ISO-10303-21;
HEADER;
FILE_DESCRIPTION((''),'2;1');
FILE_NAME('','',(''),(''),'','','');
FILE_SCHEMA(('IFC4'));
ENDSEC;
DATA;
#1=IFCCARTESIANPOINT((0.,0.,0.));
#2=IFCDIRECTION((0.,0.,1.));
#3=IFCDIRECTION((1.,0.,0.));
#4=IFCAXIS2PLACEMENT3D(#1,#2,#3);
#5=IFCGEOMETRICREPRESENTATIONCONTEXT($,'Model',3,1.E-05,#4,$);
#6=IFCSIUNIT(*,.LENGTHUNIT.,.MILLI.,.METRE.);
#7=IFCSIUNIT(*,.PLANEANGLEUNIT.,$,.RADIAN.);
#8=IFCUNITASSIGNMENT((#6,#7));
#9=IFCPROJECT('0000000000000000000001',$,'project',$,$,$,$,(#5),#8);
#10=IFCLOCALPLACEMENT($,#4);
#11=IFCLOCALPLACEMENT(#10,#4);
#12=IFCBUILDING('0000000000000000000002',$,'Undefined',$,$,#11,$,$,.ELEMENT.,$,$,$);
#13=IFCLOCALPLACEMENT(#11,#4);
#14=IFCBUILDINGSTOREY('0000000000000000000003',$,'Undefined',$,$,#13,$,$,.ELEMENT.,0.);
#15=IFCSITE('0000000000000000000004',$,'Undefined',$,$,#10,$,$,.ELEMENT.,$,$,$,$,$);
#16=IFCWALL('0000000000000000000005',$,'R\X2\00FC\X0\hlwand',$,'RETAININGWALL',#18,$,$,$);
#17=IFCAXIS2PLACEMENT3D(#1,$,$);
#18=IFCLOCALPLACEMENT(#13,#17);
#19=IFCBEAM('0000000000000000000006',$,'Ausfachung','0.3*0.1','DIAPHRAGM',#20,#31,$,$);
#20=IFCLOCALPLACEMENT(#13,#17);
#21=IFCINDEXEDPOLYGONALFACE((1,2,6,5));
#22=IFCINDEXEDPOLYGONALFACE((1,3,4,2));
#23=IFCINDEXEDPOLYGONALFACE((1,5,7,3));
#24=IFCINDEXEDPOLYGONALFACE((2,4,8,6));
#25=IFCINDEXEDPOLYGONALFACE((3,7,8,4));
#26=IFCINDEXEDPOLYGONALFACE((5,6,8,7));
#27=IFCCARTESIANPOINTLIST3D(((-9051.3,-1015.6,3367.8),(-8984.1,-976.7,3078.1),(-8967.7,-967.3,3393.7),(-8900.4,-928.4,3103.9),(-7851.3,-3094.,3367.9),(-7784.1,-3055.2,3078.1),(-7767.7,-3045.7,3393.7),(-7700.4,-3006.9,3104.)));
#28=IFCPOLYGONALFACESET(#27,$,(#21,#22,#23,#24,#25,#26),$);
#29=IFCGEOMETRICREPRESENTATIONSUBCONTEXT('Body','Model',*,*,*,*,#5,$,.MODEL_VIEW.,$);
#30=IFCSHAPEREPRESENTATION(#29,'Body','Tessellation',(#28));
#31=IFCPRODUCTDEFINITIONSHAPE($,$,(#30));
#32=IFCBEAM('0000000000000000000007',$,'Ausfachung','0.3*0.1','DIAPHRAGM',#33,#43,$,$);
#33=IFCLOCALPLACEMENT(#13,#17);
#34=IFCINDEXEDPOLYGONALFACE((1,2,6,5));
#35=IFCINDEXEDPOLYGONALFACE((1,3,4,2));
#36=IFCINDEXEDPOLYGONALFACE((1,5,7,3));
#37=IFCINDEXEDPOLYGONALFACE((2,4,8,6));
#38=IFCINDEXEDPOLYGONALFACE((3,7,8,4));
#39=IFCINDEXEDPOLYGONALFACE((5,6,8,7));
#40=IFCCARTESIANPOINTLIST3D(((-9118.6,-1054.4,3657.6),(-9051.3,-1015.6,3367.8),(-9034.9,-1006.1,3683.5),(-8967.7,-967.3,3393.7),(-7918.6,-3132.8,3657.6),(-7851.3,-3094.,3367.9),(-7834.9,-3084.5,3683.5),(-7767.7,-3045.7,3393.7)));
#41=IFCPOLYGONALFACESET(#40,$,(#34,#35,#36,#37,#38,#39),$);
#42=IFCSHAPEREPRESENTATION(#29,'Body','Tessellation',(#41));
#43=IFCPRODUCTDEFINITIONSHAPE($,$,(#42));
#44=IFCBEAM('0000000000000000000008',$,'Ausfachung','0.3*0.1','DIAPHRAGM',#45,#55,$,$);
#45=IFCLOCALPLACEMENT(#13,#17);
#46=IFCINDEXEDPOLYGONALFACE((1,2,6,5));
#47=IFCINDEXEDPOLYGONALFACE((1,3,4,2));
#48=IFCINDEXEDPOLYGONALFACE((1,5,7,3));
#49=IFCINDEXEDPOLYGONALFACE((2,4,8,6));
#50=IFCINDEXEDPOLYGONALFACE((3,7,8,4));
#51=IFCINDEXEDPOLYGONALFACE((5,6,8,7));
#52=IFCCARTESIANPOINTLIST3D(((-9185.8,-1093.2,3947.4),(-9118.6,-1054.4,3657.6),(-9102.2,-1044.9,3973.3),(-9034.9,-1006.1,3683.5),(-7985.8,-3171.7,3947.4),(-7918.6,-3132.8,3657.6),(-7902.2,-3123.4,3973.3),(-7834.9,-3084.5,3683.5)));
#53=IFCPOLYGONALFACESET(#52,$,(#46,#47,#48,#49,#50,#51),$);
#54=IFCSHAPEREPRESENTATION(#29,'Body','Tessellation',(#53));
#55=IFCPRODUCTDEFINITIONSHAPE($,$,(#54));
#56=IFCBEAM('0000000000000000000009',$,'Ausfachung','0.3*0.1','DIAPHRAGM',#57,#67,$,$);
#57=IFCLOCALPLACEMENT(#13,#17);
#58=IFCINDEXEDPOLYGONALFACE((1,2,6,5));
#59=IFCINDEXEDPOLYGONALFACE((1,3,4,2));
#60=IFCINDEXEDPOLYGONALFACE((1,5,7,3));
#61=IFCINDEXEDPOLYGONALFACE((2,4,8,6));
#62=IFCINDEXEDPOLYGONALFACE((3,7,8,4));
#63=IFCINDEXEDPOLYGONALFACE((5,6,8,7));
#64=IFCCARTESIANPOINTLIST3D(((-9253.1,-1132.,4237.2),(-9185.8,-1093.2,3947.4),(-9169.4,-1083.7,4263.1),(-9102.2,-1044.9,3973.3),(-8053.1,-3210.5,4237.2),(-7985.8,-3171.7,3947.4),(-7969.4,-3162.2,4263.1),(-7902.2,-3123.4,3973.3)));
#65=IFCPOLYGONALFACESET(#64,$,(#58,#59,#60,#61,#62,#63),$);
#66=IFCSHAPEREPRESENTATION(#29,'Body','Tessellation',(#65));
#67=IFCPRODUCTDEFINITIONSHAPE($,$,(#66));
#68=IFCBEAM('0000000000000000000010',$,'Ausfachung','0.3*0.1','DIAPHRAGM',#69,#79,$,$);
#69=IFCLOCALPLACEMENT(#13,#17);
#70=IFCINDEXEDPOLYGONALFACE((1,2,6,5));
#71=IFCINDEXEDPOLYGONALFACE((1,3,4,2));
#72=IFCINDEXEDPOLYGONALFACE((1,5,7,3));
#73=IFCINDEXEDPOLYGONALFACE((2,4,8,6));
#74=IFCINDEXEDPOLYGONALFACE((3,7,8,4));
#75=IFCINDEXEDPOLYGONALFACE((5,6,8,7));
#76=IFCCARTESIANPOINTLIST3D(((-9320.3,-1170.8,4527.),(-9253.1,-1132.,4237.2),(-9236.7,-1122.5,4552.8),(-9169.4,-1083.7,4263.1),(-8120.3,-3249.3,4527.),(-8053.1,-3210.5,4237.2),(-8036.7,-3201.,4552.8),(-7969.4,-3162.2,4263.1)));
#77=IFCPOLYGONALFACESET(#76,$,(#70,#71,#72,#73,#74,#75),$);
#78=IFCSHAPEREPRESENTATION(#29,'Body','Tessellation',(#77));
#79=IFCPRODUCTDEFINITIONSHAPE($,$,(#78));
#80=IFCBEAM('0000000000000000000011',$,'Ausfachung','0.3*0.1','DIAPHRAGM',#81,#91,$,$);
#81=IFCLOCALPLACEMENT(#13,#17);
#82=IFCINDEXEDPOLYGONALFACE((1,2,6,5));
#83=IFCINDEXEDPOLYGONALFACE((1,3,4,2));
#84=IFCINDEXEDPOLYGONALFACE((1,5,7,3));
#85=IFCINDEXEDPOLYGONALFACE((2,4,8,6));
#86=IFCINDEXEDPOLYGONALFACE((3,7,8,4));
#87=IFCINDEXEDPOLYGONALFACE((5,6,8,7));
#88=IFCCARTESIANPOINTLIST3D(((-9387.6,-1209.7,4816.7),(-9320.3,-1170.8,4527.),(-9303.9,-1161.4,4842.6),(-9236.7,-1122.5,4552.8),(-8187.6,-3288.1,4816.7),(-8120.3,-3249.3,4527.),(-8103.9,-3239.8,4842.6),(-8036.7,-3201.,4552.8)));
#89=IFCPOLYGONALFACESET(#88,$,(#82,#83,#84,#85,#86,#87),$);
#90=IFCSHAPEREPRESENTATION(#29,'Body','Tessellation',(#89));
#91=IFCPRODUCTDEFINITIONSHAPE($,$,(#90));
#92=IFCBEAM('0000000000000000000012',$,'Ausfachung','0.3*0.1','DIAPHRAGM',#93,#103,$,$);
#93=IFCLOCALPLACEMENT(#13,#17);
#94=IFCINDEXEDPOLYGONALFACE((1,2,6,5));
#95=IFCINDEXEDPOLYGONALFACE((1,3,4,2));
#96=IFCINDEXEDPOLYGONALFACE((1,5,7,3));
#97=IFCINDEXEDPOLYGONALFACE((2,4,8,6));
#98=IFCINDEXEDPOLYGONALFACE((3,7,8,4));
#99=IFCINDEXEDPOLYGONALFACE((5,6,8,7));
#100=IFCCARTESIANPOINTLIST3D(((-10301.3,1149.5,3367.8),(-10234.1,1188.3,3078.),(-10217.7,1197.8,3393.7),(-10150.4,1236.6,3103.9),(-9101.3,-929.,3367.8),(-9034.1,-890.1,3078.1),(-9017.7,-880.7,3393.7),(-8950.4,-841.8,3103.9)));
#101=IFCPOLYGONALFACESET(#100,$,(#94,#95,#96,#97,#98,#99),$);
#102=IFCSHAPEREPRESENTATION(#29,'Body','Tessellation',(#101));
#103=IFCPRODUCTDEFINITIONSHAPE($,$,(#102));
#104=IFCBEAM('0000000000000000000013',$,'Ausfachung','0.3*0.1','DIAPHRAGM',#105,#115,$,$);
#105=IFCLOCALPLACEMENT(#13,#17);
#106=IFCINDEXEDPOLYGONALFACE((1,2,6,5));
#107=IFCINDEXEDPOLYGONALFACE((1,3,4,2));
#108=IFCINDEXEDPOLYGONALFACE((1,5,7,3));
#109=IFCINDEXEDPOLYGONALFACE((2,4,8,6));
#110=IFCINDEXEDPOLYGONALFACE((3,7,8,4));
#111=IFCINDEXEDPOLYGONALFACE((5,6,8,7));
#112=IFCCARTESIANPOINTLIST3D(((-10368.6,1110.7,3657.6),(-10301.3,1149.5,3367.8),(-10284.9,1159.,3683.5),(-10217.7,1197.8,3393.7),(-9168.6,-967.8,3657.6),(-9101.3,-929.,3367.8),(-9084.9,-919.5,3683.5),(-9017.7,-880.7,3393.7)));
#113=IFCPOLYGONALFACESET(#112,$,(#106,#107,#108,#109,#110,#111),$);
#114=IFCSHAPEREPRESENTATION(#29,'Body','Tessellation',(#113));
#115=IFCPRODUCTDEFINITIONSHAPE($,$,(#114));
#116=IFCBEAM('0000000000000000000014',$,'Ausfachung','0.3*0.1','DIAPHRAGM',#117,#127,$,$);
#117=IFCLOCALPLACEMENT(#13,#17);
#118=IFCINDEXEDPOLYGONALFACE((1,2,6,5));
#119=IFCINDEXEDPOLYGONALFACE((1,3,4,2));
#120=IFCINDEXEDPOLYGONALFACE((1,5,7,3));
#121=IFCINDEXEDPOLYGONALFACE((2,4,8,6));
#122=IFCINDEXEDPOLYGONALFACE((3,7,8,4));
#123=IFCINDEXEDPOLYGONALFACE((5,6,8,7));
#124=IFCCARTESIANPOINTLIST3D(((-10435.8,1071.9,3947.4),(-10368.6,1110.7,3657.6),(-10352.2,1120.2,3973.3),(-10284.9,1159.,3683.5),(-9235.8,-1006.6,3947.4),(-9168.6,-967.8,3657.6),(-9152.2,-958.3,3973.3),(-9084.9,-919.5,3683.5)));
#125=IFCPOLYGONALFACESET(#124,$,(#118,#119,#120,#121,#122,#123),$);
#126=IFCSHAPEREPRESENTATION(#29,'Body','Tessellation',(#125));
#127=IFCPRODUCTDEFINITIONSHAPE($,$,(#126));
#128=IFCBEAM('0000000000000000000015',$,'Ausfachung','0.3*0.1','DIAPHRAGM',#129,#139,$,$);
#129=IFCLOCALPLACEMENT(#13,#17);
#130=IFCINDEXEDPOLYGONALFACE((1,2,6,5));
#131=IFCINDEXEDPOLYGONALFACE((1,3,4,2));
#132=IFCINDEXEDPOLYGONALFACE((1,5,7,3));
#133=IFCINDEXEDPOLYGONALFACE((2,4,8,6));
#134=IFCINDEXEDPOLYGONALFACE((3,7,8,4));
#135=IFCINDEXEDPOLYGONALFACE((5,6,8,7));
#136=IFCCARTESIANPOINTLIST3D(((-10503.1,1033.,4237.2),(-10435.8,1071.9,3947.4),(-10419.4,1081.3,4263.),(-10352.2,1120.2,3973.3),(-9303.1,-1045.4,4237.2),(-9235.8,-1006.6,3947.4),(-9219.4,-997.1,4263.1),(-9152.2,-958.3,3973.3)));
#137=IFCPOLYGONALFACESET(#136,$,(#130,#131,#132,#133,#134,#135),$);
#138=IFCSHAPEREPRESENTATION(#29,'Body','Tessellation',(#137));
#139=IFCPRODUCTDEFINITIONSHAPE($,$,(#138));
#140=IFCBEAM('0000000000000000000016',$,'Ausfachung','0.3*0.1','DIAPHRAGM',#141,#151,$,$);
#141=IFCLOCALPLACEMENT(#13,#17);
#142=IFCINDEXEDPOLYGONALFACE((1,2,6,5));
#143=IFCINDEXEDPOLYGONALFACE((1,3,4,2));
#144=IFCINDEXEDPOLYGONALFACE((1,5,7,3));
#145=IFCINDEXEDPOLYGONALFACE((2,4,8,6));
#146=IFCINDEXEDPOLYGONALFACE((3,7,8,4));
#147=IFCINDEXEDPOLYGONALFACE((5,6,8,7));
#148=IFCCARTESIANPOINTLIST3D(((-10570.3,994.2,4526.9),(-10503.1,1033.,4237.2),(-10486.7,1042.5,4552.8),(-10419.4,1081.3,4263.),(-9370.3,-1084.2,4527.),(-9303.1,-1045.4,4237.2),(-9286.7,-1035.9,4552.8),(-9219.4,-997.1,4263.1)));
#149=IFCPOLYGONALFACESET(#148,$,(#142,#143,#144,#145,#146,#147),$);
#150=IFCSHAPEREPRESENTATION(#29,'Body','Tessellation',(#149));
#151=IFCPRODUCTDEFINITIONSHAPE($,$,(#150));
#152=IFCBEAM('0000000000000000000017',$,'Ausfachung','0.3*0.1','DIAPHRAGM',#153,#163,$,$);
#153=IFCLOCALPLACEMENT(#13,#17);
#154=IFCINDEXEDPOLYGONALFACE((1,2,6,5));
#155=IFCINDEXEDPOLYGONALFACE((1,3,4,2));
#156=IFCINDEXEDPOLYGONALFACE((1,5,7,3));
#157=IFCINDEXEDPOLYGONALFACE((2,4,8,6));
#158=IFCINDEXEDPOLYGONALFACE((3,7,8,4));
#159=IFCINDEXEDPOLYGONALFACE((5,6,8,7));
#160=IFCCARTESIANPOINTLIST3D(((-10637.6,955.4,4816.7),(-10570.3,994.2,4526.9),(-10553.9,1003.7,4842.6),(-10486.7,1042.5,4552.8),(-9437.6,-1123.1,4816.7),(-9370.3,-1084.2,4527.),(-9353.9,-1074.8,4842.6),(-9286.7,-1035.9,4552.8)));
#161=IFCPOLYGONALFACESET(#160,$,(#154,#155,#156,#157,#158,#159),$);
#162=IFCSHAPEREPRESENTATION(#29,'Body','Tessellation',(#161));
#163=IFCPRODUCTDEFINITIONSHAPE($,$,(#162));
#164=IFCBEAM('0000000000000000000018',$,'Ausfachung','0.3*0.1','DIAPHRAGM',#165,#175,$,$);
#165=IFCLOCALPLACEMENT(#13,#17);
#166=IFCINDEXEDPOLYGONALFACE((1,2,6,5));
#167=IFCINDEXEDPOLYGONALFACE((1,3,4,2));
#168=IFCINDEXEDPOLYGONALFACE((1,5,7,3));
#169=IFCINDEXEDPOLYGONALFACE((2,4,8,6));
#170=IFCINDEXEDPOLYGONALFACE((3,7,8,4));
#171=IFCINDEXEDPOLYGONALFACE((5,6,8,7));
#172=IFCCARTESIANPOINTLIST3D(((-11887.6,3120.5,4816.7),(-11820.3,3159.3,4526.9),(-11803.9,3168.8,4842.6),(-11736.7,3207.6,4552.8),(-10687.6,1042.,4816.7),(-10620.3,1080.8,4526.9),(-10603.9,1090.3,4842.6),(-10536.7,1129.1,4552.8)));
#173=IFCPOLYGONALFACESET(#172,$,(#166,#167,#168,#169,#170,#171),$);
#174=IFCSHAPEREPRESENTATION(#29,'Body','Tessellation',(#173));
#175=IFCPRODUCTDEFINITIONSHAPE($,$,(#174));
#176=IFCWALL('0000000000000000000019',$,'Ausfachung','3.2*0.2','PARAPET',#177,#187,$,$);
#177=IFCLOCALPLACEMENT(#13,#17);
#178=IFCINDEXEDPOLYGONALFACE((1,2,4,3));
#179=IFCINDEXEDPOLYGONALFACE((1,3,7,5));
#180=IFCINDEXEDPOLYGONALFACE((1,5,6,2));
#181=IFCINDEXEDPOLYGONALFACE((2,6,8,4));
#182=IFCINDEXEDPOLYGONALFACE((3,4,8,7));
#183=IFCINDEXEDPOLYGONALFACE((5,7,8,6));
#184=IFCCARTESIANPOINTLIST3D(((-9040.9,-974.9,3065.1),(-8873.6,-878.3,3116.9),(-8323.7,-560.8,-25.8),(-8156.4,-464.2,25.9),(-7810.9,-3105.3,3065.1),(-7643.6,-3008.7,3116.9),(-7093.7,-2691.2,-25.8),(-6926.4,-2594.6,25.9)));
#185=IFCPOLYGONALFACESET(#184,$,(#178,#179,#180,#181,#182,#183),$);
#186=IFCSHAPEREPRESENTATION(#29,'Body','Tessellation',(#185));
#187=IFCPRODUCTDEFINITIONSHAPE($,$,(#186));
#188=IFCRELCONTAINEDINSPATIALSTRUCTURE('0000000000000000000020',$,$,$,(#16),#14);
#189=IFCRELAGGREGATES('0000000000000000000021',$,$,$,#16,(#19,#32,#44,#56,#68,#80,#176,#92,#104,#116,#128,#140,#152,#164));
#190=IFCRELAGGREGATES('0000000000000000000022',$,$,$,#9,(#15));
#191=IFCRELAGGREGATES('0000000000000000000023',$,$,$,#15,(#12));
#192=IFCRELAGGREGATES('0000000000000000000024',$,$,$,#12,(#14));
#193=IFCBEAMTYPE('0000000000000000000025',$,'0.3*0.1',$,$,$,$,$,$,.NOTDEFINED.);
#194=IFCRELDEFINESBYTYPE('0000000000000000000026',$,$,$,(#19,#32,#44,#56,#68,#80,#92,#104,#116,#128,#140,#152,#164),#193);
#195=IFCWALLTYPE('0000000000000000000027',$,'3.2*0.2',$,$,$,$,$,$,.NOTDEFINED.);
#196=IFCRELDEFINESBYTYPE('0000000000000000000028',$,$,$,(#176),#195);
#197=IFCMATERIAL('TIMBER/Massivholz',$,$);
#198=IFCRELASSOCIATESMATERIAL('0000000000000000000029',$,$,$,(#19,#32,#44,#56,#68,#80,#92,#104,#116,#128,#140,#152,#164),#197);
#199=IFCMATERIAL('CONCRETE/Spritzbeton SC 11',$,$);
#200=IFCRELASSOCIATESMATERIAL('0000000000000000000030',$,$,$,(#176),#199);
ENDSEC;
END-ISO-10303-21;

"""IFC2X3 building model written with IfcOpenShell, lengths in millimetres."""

from ifc_helpers import new_model, si_unit, frame, frame_2d, origin_with_axes, origin_2d_with_axis, place, context, subcontext, project, spatial, rectangle, extrude, material, type_object, element, aggregate, save


model = new_model("IFC2X3")

# Units and contexts
model_context = context("Model", 3, precision=1e-05, world=origin_with_axes())
body_context = subcontext(model_context, "Body", "Model", "MODEL_VIEW")
ifc_project = project(units=[si_unit("LENGTHUNIT", "METRE", prefix="MILLI"), si_unit("PLANEANGLEUNIT", "RADIAN")], contexts=[model_context])

# Site, building, storey
site_placement = place(None, origin_with_axes())
site = spatial("IfcSite", under=ifc_project, at=site_placement, Name="Undefined", CompositionType="ELEMENT")
building_placement = place(site_placement, origin_with_axes())
building = spatial("IfcBuilding", under=site, at=building_placement, Name="Undefined", CompositionType="ELEMENT")
storey_placement = place(building_placement, origin_with_axes())
storey = spatial("IfcBuildingStorey", under=building, at=storey_placement, Name="Undefined", CompositionType="ELEMENT", Elevation=0.0)

# Wall
wall_1_placement = place(storey_placement, origin_with_axes())
wall_1 = element("IfcWall", 1, at=wall_1_placement, inside=storey, Name="Rühlwand", ObjectType="RETAININGWALL")

# Beams
ifc_material_1 = material(Name="TIMBER/Massivholz")
beam_type_1 = type_object("IfcBeamType", Name="0.3*0.1", PredefinedType="NOTDEFINED")
beam_1_placement = place(wall_1_placement, frame((-8975.9, -972.0, 3235.9), z_axis=(0.224147, 0.129405, -0.965926), x_axis=(0.499999, -0.866026, 0.000005)))
beam_1 = element("IfcBeam", 2, at=beam_1_placement, type_object=beam_type_1, material=ifc_material_1, Name="Ausfachung", Description="0.3*0.1", ObjectType="DIAPHRAGM", context=body_context, shape_type="SweptSolid", body=[
    extrude(rectangle(XDim=100.0, YDim=300.0, at=origin_2d_with_axis()), frame((2400.0, 0.0, 0.0), z_axis=(-1.0, 0.0, 0.0), x_axis=(0.0, -1.0, 0.0)), (0.0, 0.0, 1.0), 2400.0),
])
beam_2_placement = place(wall_1_placement, frame((-9043.1, -1010.8, 3525.7), z_axis=(0.224147, 0.129405, -0.965926), x_axis=(0.499999, -0.866026, 0.000005)))
beam_2 = element("IfcBeam", 3, at=beam_2_placement, type_object=beam_type_1, material=ifc_material_1, Name="Ausfachung", Description="0.3*0.1", ObjectType="DIAPHRAGM", context=body_context, shape_type="SweptSolid", body=[
    extrude(rectangle(XDim=100.0, YDim=300.0, at=origin_2d_with_axis()), frame((2400.0, 0.0, 0.0), z_axis=(-1.0, 0.0, 0.0), x_axis=(0.0, -1.0, 0.0)), (0.0, 0.0, 1.0), 2400.0),
])
beam_3_placement = place(wall_1_placement, frame((-9110.4, -1049.6, 3815.4), z_axis=(0.224147, 0.129405, -0.965926), x_axis=(0.499999, -0.866026, 0.000005)))
beam_3 = element("IfcBeam", 4, at=beam_3_placement, type_object=beam_type_1, material=ifc_material_1, Name="Ausfachung", Description="0.3*0.1", ObjectType="DIAPHRAGM", context=body_context, shape_type="SweptSolid", body=[
    extrude(rectangle(XDim=100.0, YDim=300.0, at=origin_2d_with_axis()), frame((2400.0, 0.0, 0.0), z_axis=(-1.0, 0.0, 0.0), x_axis=(0.0, -1.0, 0.0)), (0.0, 0.0, 1.0), 2400.0),
])
beam_4_placement = place(wall_1_placement, frame((-9177.6, -1088.5, 4105.2), z_axis=(0.224147, 0.129405, -0.965926), x_axis=(0.499999, -0.866026, 0.000005)))
beam_4 = element("IfcBeam", 5, at=beam_4_placement, type_object=beam_type_1, material=ifc_material_1, Name="Ausfachung", Description="0.3*0.1", ObjectType="DIAPHRAGM", context=body_context, shape_type="SweptSolid", body=[
    extrude(rectangle(XDim=100.0, YDim=300.0, at=origin_2d_with_axis()), frame((2400.0, 0.0, 0.0), z_axis=(-1.0, 0.0, 0.0), x_axis=(0.0, -1.0, 0.0)), (0.0, 0.0, 1.0), 2400.0),
])
beam_5_placement = place(wall_1_placement, frame((-9244.9, -1127.3, 4395.0), z_axis=(0.224147, 0.129405, -0.965926), x_axis=(0.499999, -0.866026, 0.000005)))
beam_5 = element("IfcBeam", 6, at=beam_5_placement, type_object=beam_type_1, material=ifc_material_1, Name="Ausfachung", Description="0.3*0.1", ObjectType="DIAPHRAGM", context=body_context, shape_type="SweptSolid", body=[
    extrude(rectangle(XDim=100.0, YDim=300.0, at=origin_2d_with_axis()), frame((2400.0, 0.0, 0.0), z_axis=(-1.0, 0.0, 0.0), x_axis=(0.0, -1.0, 0.0)), (0.0, 0.0, 1.0), 2400.0),
])
beam_6_placement = place(wall_1_placement, frame((-9312.1, -1166.1, 4684.8), z_axis=(0.224147, 0.129405, -0.965926), x_axis=(0.499999, -0.866026, 0.000005)))
beam_6 = element("IfcBeam", 7, at=beam_6_placement, type_object=beam_type_1, material=ifc_material_1, Name="Ausfachung", Description="0.3*0.1", ObjectType="DIAPHRAGM", context=body_context, shape_type="SweptSolid", body=[
    extrude(rectangle(XDim=100.0, YDim=300.0, at=origin_2d_with_axis()), frame((2400.0, 0.0, 0.0), z_axis=(-1.0, 0.0, 0.0), x_axis=(0.0, -1.0, 0.0)), (0.0, 0.0, 1.0), 2400.0),
])
beam_7_placement = place(wall_1_placement, frame((-10225.9, 1193.1, 3235.9), z_axis=(0.224147, 0.129405, -0.965926), x_axis=(0.499999, -0.866026, 0.000005)))
beam_7 = element("IfcBeam", 8, at=beam_7_placement, type_object=beam_type_1, material=ifc_material_1, Name="Ausfachung", Description="0.3*0.1", ObjectType="DIAPHRAGM", context=body_context, shape_type="SweptSolid", body=[
    extrude(rectangle(XDim=100.0, YDim=300.0, at=origin_2d_with_axis()), frame((2400.0, 0.0, 0.0), z_axis=(-1.0, 0.0, 0.0), x_axis=(0.0, -1.0, 0.0)), (0.0, 0.0, 1.0), 2400.0),
])
beam_8_placement = place(wall_1_placement, frame((-10293.1, 1154.2, 3525.7), z_axis=(0.224147, 0.129405, -0.965926), x_axis=(0.499999, -0.866026, 0.000005)))
beam_8 = element("IfcBeam", 9, at=beam_8_placement, type_object=beam_type_1, material=ifc_material_1, Name="Ausfachung", Description="0.3*0.1", ObjectType="DIAPHRAGM", context=body_context, shape_type="SweptSolid", body=[
    extrude(rectangle(XDim=100.0, YDim=300.0, at=origin_2d_with_axis()), frame((2400.0, 0.0, 0.0), z_axis=(-1.0, 0.0, 0.0), x_axis=(0.0, -1.0, 0.0)), (0.0, 0.0, 1.0), 2400.0),
])
beam_9_placement = place(wall_1_placement, frame((-10360.4, 1115.4, 3815.4), z_axis=(0.224147, 0.129405, -0.965926), x_axis=(0.499999, -0.866026, 0.000005)))
beam_9 = element("IfcBeam", 10, at=beam_9_placement, type_object=beam_type_1, material=ifc_material_1, Name="Ausfachung", Description="0.3*0.1", ObjectType="DIAPHRAGM", context=body_context, shape_type="SweptSolid", body=[
    extrude(rectangle(XDim=100.0, YDim=300.0, at=origin_2d_with_axis()), frame((2400.0, 0.0, 0.0), z_axis=(-1.0, 0.0, 0.0), x_axis=(0.0, -1.0, 0.0)), (0.0, 0.0, 1.0), 2400.0),
])
beam_10_placement = place(wall_1_placement, frame((-10427.6, 1076.6, 4105.2), z_axis=(0.224147, 0.129405, -0.965926), x_axis=(0.499999, -0.866026, 0.000005)))
beam_10 = element("IfcBeam", 11, at=beam_10_placement, type_object=beam_type_1, material=ifc_material_1, Name="Ausfachung", Description="0.3*0.1", ObjectType="DIAPHRAGM", context=body_context, shape_type="SweptSolid", body=[
    extrude(rectangle(XDim=100.0, YDim=300.0, at=origin_2d_with_axis()), frame((2400.0, 0.0, 0.0), z_axis=(-1.0, 0.0, 0.0), x_axis=(0.0, -1.0, 0.0)), (0.0, 0.0, 1.0), 2400.0),
])
beam_11_placement = place(wall_1_placement, frame((-10494.9, 1037.8, 4395.0), z_axis=(0.224147, 0.129405, -0.965926), x_axis=(0.499999, -0.866026, 0.000005)))
beam_11 = element("IfcBeam", 12, at=beam_11_placement, type_object=beam_type_1, material=ifc_material_1, Name="Ausfachung", Description="0.3*0.1", ObjectType="DIAPHRAGM", context=body_context, shape_type="SweptSolid", body=[
    extrude(rectangle(XDim=100.0, YDim=300.0, at=origin_2d_with_axis()), frame((2400.0, 0.0, 0.0), z_axis=(-1.0, 0.0, 0.0), x_axis=(0.0, -1.0, 0.0)), (0.0, 0.0, 1.0), 2400.0),
])
beam_12_placement = place(wall_1_placement, frame((-10562.1, 999.0, 4684.8), z_axis=(0.224147, 0.129405, -0.965926), x_axis=(0.499999, -0.866026, 0.000005)))
beam_12 = element("IfcBeam", 13, at=beam_12_placement, type_object=beam_type_1, material=ifc_material_1, Name="Ausfachung", Description="0.3*0.1", ObjectType="DIAPHRAGM", context=body_context, shape_type="SweptSolid", body=[
    extrude(rectangle(XDim=100.0, YDim=300.0, at=origin_2d_with_axis()), frame((2400.0, 0.0, 0.0), z_axis=(-1.0, 0.0, 0.0), x_axis=(0.0, -1.0, 0.0)), (0.0, 0.0, 1.0), 2400.0),
])
beam_13_placement = place(wall_1_placement, frame((-11812.1, 3164.0, 4684.8), z_axis=(0.224147, 0.129405, -0.965926), x_axis=(0.499999, -0.866026, 0.000005)))
beam_13 = element("IfcBeam", 14, at=beam_13_placement, type_object=beam_type_1, material=ifc_material_1, Name="Ausfachung", Description="0.3*0.1", ObjectType="DIAPHRAGM", context=body_context, shape_type="SweptSolid", body=[
    extrude(rectangle(XDim=100.0, YDim=300.0, at=origin_2d_with_axis()), frame((2400.0, 0.0, 0.0), z_axis=(-1.0, 0.0, 0.0), x_axis=(0.0, -1.0, 0.0)), (0.0, 0.0, 1.0), 2400.0),
])

# Wall
ifc_material_2 = material(Name="CONCRETE/Spritzbeton SC 11")
wall_type = type_object("IfcWallType", Name="3.2*0.2", PredefinedType="NOTDEFINED")
wall_2_placement = place(wall_1_placement, frame((-8240.0, -512.5, 0.0), z_axis=(-0.224147, -0.129405, 0.965926), x_axis=(0.499999, -0.866026, 0.000005)))
wall_2 = element("IfcWall", 15, at=wall_2_placement, type_object=wall_type, material=ifc_material_2, Name="Ausfachung", Description="3.2*0.2", ObjectType="PARAPET", context=body_context, shape_type="SweptSolid", body=[
    extrude(rectangle(XDim=2460.0, YDim=200.0, at=frame_2d((0.0, 1230.0), x_axis=(0.0, -1.0))), frame((0.0, 0.0, 0.0), z_axis=(0.0, 0.0, 1.0), x_axis=(0.0, -1.0, 0.0)), (0.0, 0.0, 1.0), 3200.0),
])

aggregate(wall_1, [beam_1, beam_2, beam_3, beam_4, beam_5, beam_6, wall_2, beam_7, beam_8, beam_9, beam_10, beam_11, beam_12, beam_13])

save(model, "model.ifc")
